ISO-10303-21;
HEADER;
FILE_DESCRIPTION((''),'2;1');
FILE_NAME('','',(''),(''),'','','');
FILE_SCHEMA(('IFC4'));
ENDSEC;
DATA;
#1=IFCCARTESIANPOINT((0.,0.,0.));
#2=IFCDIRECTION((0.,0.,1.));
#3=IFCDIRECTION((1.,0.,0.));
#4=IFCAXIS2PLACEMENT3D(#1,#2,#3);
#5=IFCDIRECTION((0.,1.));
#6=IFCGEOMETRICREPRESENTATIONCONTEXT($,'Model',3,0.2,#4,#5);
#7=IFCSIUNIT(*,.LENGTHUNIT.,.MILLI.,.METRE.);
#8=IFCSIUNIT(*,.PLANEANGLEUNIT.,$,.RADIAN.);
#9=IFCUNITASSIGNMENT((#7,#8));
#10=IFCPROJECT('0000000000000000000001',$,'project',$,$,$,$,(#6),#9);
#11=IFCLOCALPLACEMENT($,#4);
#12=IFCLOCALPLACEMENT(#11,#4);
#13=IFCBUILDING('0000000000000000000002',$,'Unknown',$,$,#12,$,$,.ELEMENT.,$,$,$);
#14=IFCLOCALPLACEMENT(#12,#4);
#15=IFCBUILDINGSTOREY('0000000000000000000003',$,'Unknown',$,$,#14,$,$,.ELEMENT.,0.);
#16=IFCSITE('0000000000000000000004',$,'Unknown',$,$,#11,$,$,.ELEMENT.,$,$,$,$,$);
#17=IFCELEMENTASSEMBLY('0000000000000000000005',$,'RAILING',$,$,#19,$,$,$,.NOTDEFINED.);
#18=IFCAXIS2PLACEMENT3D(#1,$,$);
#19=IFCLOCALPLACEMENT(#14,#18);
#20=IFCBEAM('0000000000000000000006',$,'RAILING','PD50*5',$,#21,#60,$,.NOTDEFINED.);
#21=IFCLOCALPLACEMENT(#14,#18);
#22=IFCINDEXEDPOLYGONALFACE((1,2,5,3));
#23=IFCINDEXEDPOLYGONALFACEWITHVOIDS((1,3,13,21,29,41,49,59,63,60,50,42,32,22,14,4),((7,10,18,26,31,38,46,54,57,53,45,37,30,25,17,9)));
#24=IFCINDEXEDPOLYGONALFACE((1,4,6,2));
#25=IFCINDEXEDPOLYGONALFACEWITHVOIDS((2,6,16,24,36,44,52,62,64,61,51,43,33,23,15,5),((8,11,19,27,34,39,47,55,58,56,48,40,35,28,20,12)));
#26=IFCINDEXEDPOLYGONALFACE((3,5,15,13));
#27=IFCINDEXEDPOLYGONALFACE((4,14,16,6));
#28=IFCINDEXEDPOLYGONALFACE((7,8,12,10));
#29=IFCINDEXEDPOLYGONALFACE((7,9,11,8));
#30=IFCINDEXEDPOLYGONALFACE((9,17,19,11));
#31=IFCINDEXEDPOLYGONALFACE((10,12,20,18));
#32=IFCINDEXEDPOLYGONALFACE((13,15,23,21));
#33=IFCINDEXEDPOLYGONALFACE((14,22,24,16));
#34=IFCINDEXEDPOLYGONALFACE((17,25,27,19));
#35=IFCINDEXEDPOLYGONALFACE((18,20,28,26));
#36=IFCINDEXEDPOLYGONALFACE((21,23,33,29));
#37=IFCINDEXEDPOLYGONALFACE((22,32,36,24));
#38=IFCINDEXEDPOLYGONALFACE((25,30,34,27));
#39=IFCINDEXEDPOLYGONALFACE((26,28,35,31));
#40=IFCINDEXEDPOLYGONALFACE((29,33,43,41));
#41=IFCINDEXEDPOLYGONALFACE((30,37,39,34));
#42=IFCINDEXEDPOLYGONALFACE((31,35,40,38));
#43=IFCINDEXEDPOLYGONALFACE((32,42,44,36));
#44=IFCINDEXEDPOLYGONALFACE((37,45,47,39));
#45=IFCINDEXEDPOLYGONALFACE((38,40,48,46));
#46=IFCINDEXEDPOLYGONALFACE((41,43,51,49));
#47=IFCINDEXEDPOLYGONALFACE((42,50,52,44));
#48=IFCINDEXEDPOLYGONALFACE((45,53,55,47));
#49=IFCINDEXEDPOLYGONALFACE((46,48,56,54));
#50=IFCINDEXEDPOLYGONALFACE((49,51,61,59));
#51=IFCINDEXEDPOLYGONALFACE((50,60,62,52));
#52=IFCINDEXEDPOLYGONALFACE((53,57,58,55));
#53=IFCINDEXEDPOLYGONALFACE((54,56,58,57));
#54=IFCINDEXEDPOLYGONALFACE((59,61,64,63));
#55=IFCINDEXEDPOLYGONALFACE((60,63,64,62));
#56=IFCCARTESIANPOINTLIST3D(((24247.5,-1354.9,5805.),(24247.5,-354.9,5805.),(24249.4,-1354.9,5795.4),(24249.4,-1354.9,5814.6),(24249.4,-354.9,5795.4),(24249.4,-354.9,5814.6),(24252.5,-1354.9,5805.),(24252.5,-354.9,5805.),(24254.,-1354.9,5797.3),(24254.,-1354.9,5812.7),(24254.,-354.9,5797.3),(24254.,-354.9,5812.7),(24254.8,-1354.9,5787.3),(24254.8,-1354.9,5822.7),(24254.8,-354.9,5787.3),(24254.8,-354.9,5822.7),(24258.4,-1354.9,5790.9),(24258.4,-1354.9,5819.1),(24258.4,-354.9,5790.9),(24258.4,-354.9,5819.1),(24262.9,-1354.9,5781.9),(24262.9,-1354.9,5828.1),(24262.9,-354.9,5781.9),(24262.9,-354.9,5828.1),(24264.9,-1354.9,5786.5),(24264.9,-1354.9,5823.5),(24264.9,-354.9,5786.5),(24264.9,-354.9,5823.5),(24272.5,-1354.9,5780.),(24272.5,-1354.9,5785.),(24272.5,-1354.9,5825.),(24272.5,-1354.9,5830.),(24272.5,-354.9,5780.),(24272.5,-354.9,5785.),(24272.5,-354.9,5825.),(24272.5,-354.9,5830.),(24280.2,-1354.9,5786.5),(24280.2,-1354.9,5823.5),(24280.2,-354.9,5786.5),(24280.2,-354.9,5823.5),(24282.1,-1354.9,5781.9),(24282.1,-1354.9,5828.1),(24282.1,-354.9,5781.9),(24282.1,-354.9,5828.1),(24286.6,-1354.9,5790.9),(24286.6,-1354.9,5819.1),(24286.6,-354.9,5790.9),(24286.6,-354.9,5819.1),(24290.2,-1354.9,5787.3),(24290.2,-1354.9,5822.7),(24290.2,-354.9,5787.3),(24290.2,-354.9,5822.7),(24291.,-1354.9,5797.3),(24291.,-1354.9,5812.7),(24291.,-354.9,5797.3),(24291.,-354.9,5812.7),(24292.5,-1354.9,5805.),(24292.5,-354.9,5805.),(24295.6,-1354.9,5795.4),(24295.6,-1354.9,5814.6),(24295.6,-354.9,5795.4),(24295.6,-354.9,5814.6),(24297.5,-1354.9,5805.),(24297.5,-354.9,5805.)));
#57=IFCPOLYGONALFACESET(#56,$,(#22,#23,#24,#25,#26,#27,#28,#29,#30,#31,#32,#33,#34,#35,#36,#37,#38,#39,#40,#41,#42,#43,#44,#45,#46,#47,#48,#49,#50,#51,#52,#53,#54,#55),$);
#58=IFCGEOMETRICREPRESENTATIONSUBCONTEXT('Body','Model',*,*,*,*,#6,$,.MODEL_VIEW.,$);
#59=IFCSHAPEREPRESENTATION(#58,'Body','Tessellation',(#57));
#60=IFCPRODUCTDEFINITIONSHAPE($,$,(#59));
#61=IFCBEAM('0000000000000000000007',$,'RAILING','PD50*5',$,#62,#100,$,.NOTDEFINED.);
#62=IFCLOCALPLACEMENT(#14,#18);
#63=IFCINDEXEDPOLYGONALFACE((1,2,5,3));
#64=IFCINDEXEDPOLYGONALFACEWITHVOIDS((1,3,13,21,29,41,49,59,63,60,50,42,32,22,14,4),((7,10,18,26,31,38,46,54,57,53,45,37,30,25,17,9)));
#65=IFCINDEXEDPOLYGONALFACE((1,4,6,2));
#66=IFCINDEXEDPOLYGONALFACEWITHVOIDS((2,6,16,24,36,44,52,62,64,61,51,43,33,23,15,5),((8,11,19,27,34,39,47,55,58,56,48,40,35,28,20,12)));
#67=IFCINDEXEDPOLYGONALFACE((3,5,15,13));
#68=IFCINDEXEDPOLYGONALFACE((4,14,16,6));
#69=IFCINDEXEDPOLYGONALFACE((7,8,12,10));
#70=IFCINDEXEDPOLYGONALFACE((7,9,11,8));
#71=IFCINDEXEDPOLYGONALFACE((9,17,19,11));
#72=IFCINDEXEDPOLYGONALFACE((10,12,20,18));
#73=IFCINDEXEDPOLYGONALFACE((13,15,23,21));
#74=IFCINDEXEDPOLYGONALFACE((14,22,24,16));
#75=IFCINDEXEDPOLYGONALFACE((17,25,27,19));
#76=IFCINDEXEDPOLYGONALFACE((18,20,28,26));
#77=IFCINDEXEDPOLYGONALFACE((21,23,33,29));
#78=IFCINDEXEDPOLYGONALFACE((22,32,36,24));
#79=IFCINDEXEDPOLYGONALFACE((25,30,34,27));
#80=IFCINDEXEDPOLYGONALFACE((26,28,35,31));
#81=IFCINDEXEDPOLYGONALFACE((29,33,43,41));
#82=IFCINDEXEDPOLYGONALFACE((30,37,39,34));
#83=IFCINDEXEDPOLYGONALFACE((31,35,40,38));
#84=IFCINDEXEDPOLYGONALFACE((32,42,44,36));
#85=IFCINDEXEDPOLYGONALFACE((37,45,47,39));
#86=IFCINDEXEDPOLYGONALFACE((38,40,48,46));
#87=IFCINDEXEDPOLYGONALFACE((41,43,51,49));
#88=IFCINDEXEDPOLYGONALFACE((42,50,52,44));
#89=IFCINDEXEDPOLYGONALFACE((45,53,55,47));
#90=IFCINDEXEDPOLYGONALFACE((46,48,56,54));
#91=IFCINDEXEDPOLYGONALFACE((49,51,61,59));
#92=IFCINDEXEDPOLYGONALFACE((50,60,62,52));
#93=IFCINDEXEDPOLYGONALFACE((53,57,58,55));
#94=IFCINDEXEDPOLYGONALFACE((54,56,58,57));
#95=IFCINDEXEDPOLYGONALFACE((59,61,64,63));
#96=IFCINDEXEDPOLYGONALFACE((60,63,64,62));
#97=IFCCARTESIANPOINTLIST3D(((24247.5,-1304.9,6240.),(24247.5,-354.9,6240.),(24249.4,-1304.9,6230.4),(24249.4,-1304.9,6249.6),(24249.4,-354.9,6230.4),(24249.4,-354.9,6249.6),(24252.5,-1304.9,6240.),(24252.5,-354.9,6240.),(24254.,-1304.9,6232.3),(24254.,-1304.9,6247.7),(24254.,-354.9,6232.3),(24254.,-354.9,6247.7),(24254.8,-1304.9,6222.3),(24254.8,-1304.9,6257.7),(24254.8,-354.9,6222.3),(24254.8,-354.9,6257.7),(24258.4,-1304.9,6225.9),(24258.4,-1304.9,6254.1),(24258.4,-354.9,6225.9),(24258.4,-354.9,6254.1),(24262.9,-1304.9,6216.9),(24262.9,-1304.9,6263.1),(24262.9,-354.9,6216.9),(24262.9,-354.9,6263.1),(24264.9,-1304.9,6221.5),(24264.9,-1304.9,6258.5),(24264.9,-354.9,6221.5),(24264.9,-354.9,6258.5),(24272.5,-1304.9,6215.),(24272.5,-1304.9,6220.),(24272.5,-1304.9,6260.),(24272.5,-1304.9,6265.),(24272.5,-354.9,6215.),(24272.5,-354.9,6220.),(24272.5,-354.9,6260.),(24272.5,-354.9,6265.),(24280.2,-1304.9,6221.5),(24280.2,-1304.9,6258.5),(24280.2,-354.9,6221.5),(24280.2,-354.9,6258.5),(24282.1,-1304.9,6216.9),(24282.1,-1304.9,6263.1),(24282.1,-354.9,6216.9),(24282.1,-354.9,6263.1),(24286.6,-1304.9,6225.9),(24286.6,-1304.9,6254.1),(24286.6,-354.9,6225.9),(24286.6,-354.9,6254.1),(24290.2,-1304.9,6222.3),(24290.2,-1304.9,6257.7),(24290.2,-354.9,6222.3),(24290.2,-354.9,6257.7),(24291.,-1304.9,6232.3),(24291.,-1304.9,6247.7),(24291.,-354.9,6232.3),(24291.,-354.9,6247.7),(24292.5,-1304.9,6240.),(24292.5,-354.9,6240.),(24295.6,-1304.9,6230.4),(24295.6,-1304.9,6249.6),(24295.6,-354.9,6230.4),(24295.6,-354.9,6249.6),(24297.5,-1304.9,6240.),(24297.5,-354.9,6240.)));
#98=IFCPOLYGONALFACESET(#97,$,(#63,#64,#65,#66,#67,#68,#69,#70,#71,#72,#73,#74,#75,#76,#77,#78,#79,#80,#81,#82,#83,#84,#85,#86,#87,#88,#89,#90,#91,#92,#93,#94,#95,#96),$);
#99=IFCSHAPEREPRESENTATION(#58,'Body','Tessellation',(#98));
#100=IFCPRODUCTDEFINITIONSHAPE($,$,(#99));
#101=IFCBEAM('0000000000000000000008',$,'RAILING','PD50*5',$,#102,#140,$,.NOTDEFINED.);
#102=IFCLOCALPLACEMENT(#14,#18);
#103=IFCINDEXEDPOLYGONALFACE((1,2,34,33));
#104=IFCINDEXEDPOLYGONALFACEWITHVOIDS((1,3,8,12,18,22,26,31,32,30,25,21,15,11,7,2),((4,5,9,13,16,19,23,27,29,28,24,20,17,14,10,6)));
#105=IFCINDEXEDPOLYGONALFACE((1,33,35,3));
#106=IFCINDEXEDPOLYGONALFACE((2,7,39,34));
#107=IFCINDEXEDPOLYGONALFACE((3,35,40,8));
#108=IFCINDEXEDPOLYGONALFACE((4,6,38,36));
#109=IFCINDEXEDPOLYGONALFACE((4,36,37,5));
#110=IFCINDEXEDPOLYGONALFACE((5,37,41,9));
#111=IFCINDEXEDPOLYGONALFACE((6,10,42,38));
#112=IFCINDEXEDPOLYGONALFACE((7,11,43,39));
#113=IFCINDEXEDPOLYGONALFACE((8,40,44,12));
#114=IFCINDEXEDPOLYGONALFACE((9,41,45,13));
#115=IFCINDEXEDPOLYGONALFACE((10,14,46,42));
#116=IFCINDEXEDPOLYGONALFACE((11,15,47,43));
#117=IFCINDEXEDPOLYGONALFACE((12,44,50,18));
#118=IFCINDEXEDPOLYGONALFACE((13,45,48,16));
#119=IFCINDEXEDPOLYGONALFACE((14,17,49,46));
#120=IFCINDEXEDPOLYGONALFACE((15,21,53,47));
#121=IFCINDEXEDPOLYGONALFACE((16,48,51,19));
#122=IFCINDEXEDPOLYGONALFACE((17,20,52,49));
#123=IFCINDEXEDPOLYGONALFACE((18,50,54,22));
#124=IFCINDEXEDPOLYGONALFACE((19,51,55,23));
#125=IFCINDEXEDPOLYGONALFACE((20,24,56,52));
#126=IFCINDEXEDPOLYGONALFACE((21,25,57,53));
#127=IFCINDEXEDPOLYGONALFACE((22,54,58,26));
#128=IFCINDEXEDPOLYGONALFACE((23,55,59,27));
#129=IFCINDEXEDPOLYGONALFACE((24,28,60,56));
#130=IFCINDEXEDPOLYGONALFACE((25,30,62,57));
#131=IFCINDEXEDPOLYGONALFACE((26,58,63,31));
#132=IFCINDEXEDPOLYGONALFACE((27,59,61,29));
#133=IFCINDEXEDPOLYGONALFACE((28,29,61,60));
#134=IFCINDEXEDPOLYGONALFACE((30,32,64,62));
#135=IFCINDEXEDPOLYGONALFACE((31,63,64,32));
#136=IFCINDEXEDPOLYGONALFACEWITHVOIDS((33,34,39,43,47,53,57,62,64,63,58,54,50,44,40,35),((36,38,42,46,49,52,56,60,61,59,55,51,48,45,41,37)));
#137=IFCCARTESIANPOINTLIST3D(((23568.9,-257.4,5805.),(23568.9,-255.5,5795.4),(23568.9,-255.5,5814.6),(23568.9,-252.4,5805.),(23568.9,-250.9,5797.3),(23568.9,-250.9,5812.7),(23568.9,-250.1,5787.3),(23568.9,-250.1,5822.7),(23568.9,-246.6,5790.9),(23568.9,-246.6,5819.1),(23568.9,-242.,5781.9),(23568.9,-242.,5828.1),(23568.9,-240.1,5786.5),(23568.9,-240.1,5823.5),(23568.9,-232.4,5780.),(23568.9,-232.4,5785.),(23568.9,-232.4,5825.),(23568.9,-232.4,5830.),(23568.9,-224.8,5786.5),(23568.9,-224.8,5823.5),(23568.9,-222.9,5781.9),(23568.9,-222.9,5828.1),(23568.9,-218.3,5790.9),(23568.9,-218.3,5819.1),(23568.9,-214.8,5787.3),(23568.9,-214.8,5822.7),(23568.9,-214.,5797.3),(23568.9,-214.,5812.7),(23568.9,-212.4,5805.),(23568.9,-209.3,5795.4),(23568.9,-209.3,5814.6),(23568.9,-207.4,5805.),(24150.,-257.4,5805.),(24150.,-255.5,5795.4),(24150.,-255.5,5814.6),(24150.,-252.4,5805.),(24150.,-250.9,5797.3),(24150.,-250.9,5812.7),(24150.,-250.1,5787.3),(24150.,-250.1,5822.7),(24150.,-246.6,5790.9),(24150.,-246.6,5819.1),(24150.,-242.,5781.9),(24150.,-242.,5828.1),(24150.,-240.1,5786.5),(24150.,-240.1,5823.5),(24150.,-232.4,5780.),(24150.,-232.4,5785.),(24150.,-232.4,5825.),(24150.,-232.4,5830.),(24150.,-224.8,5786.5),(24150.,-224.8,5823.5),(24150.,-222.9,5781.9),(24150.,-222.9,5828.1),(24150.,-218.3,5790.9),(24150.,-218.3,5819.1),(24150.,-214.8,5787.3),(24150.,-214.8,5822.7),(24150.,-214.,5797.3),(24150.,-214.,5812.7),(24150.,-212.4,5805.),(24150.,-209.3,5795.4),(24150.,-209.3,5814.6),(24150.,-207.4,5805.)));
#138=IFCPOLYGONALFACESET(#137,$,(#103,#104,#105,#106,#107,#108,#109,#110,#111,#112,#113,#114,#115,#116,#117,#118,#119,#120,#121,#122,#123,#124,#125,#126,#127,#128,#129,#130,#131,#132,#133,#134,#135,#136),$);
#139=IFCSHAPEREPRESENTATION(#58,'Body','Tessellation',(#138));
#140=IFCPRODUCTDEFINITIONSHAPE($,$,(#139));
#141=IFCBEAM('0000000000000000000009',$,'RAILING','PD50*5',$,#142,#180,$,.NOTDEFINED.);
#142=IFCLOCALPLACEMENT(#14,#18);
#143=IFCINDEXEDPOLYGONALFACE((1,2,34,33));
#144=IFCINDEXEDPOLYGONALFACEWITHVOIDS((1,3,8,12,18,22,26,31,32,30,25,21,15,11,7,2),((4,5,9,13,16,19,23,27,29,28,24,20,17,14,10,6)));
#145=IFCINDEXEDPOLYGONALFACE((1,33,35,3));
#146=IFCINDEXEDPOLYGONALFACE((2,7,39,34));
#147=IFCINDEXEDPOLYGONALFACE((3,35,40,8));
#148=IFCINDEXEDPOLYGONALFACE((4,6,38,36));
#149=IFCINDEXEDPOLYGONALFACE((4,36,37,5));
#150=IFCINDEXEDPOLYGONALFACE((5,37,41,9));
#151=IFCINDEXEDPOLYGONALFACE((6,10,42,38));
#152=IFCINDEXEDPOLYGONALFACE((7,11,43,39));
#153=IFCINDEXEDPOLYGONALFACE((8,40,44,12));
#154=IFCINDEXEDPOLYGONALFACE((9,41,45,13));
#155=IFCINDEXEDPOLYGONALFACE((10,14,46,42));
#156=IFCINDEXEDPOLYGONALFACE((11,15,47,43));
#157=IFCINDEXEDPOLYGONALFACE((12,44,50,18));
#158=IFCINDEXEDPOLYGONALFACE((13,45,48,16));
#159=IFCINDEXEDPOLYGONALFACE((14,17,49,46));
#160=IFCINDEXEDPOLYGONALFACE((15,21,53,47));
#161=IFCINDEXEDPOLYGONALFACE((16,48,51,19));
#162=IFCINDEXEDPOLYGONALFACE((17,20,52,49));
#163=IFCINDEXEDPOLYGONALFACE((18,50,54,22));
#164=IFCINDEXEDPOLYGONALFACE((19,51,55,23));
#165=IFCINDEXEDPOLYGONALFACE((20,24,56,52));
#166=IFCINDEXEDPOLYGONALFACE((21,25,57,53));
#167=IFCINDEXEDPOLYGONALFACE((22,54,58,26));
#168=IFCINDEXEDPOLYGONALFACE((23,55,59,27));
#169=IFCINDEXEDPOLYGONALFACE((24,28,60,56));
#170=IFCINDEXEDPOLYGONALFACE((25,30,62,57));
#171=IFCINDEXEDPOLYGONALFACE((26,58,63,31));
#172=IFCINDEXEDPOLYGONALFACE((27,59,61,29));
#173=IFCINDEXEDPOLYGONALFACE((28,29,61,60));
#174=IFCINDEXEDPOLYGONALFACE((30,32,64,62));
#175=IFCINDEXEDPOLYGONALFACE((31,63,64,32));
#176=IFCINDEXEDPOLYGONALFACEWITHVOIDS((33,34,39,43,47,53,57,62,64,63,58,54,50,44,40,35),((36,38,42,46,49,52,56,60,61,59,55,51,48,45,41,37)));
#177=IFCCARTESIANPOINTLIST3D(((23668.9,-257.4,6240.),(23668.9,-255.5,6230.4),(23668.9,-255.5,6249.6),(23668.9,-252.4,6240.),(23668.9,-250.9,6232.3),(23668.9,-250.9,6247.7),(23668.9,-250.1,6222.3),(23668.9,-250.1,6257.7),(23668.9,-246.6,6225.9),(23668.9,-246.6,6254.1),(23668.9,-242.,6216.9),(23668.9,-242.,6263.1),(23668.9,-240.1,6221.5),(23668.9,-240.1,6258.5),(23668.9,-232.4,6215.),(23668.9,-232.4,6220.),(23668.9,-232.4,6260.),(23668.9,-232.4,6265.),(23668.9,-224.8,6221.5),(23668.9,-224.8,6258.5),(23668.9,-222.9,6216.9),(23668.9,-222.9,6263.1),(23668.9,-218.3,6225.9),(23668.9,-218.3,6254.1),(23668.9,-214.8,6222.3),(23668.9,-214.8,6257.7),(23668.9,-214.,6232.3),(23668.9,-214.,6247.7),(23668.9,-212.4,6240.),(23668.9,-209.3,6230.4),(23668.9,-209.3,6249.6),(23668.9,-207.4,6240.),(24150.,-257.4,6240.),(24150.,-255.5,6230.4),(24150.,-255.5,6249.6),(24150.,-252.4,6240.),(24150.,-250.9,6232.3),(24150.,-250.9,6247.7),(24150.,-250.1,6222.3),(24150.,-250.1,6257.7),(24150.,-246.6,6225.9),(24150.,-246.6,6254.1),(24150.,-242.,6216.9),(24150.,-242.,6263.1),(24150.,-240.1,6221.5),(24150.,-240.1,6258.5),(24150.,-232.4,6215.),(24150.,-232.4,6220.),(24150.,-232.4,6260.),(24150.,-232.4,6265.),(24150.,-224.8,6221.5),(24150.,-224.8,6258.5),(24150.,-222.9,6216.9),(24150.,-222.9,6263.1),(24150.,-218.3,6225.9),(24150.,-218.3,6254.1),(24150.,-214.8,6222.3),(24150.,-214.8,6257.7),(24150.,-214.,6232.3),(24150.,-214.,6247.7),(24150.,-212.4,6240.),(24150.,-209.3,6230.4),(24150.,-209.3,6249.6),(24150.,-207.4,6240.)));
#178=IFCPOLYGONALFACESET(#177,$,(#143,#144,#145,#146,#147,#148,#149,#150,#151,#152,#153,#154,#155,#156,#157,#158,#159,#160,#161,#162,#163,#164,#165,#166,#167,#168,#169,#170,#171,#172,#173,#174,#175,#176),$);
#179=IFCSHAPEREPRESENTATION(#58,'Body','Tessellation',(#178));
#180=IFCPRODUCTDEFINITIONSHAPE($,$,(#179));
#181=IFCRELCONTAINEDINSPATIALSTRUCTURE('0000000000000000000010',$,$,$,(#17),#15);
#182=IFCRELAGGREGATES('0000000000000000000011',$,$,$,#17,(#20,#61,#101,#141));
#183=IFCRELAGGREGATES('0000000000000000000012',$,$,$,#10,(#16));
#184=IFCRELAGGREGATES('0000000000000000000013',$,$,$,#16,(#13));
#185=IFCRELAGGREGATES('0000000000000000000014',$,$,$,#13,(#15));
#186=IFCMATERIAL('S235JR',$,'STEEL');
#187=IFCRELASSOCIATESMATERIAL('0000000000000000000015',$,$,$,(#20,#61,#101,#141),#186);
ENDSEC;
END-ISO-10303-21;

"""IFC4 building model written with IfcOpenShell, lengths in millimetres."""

from ifc_helpers import new_model, si_unit, direction, frame, origin_with_axes, place, context, subcontext, project, spatial, line, indexed_curve, outline, extrude, material, element, aggregate, save


model = new_model("IFC4")

# Units and contexts
model_context = context("Model", 3, precision=0.2, world=origin_with_axes(), true_north=direction((0.0, 1.0)))
body_context = subcontext(model_context, "Body", "Model", "MODEL_VIEW")
ifc_project = project(units=[si_unit("LENGTHUNIT", "METRE", prefix="MILLI"), si_unit("PLANEANGLEUNIT", "RADIAN")], contexts=[model_context])

# Site, building, storey
site_placement = place(None, origin_with_axes())
site = spatial("IfcSite", under=ifc_project, at=site_placement, Name="Unknown", CompositionType="ELEMENT")
building_placement = place(site_placement, origin_with_axes())
building = spatial("IfcBuilding", under=site, at=building_placement, Name="Unknown", CompositionType="ELEMENT")
storey_placement = place(building_placement, origin_with_axes())
storey = spatial("IfcBuildingStorey", under=building, at=storey_placement, Name="Unknown", CompositionType="ELEMENT", Elevation=0.0)

# Shared definitions
ifc_material_1 = material(Name="S235JR", Category="STEEL")

# Element assembly, beams
assembly_1_placement = place(storey_placement, frame((24272.5, -1304.9, 6240.0), z_axis=(-1.0, 0.0, 0.0), x_axis=(0.0, 1.0, 0.0)))
assembly_1 = element("IfcElementAssembly", 1, at=assembly_1_placement, inside=storey, Name="RAILING", PredefinedType="NOTDEFINED")
beam_1_placement = place(assembly_1_placement, frame((-50.0, 435.0, 0.0), z_axis=(0.0, -1.0, 0.0), x_axis=(1.0, 0.0, 0.0)))
beam_1 = element("IfcBeam", 2, at=beam_1_placement, material=ifc_material_1, Name="RAILING", Description="PD50*5", PredefinedType="NOTDEFINED", context=body_context, shape_type="SolidModel", body=[
    extrude(outline(indexed_curve([(25.0, 0.0), (23.1, 9.6), (17.7, 17.7), (9.6, 23.1), (0.0, 25.0), (-9.6, 23.1), (-17.7, 17.7), (-23.1, 9.6), (-25.0, 0.0), (-23.1, -9.6), (-17.7, -17.7), (-9.6, -23.1), (0.0, -25.0), (9.6, -23.1), (17.7, -17.7), (23.1, -9.6)], segments=[line(1, 2, 3, 4, 5, 6, 7, 8, 9, 10, 11, 12, 13, 14, 15, 16, 1)]), holes=[indexed_curve([(20.0, 0.0), (18.5, -7.7), (14.1, -14.1), (7.7, -18.5), (0.0, -20.0), (-7.7, -18.5), (-14.1, -14.1), (-18.5, -7.7), (-20.0, 0.0), (-18.5, 7.7), (-14.1, 14.1), (-7.7, 18.5), (0.0, 20.0), (7.7, 18.5), (14.1, 14.1), (18.5, 7.7)], segments=[line(1, 2, 3, 4, 5, 6, 7, 8, 9, 10, 11, 12, 13, 14, 15, 16, 1)])]), frame((0.0, 0.0, 0.0), z_axis=(-1.0, 0.0, 0.0), x_axis=(0.0, 0.0, 1.0)), (0.0, 0.0, -1.0), 1000.0),
])
beam_2_placement = place(assembly_1_placement, origin_with_axes())
beam_2 = element("IfcBeam", 3, at=beam_2_placement, material=ifc_material_1, Name="RAILING", Description="PD50*5", PredefinedType="NOTDEFINED", context=body_context, shape_type="SolidModel", body=[
    extrude(outline(indexed_curve([(25.0, 0.0), (23.1, 9.6), (17.7, 17.7), (9.6, 23.1), (0.0, 25.0), (-9.6, 23.1), (-17.7, 17.7), (-23.1, 9.6), (-25.0, 0.0), (-23.1, -9.6), (-17.7, -17.7), (-9.6, -23.1), (0.0, -25.0), (9.6, -23.1), (17.7, -17.7), (23.1, -9.6)], segments=[line(1, 2, 3, 4, 5, 6, 7, 8, 9, 10, 11, 12, 13, 14, 15, 16, 1)]), holes=[indexed_curve([(20.0, 0.0), (18.5, -7.7), (14.1, -14.1), (7.7, -18.5), (0.0, -20.0), (-7.7, -18.5), (-14.1, -14.1), (-18.5, -7.7), (-20.0, 0.0), (-18.5, 7.7), (-14.1, 14.1), (-7.7, 18.5), (0.0, 20.0), (7.7, 18.5), (14.1, 14.1), (18.5, 7.7)], segments=[line(1, 2, 3, 4, 5, 6, 7, 8, 9, 10, 11, 12, 13, 14, 15, 16, 1)])]), frame((0.0, 0.0, 0.0), z_axis=(-1.0, 0.0, 0.0), x_axis=(0.0, 0.0, 1.0)), (0.0, 0.0, -1.0), 950.0),
])
beam_3_placement = place(assembly_1_placement, frame((1072.5, 435.0, 122.5), z_axis=(0.0, -1.0, 0.0), x_axis=(0.0, 0.0, 1.0)))
beam_3 = element("IfcBeam", 4, at=beam_3_placement, material=ifc_material_1, Name="RAILING", Description="PD50*5", PredefinedType="NOTDEFINED", context=body_context, shape_type="SolidModel", body=[
    extrude(outline(indexed_curve([(25.0, 0.0), (23.1, 9.6), (17.7, 17.7), (9.6, 23.1), (0.0, 25.0), (-9.6, 23.1), (-17.7, 17.7), (-23.1, 9.6), (-25.0, 0.0), (-23.1, -9.6), (-17.7, -17.7), (-9.6, -23.1), (0.0, -25.0), (9.6, -23.1), (17.7, -17.7), (23.1, -9.6)], segments=[line(1, 2, 3, 4, 5, 6, 7, 8, 9, 10, 11, 12, 13, 14, 15, 16, 1)]), holes=[indexed_curve([(20.0, 0.0), (18.5, -7.7), (14.1, -14.1), (7.7, -18.5), (0.0, -20.0), (-7.7, -18.5), (-14.1, -14.1), (-18.5, -7.7), (-20.0, 0.0), (-18.5, 7.7), (-14.1, 14.1), (-7.7, 18.5), (0.0, 20.0), (7.7, 18.5), (14.1, 14.1), (18.5, 7.7)], segments=[line(1, 2, 3, 4, 5, 6, 7, 8, 9, 10, 11, 12, 13, 14, 15, 16, 1)])]), frame((0.0, 0.0, 0.0), z_axis=(-1.0, 0.0, 0.0), x_axis=(0.0, 0.0, 1.0)), (0.0, 0.0, -1.0), 581.1),
])
beam_4_placement = place(assembly_1_placement, frame((1072.5, 0.0, 122.5), z_axis=(-1.0, 0.0, 0.0), x_axis=(0.0, 0.0, 1.0)))
beam_4 = element("IfcBeam", 5, at=beam_4_placement, material=ifc_material_1, Name="RAILING", Description="PD50*5", PredefinedType="NOTDEFINED", context=body_context, shape_type="SolidModel", body=[
    extrude(outline(indexed_curve([(25.0, 0.0), (23.1, 9.6), (17.7, 17.7), (9.6, 23.1), (0.0, 25.0), (-9.6, 23.1), (-17.7, 17.7), (-23.1, 9.6), (-25.0, 0.0), (-23.1, -9.6), (-17.7, -17.7), (-9.6, -23.1), (0.0, -25.0), (9.6, -23.1), (17.7, -17.7), (23.1, -9.6)], segments=[line(1, 2, 3, 4, 5, 6, 7, 8, 9, 10, 11, 12, 13, 14, 15, 16, 1)]), holes=[indexed_curve([(20.0, 0.0), (18.5, -7.7), (14.1, -14.1), (7.7, -18.5), (0.0, -20.0), (-7.7, -18.5), (-14.1, -14.1), (-18.5, -7.7), (-20.0, 0.0), (-18.5, 7.7), (-14.1, 14.1), (-7.7, 18.5), (0.0, 20.0), (7.7, 18.5), (14.1, 14.1), (18.5, 7.7)], segments=[line(1, 2, 3, 4, 5, 6, 7, 8, 9, 10, 11, 12, 13, 14, 15, 16, 1)])]), frame((0.0, 0.0, 0.0), z_axis=(-1.0, 0.0, 0.0), x_axis=(0.0, 0.0, 1.0)), (0.0, 0.0, -1.0), 481.1),
])

aggregate(assembly_1, [beam_1, beam_2, beam_3, beam_4])

save(model, "model.ifc")
